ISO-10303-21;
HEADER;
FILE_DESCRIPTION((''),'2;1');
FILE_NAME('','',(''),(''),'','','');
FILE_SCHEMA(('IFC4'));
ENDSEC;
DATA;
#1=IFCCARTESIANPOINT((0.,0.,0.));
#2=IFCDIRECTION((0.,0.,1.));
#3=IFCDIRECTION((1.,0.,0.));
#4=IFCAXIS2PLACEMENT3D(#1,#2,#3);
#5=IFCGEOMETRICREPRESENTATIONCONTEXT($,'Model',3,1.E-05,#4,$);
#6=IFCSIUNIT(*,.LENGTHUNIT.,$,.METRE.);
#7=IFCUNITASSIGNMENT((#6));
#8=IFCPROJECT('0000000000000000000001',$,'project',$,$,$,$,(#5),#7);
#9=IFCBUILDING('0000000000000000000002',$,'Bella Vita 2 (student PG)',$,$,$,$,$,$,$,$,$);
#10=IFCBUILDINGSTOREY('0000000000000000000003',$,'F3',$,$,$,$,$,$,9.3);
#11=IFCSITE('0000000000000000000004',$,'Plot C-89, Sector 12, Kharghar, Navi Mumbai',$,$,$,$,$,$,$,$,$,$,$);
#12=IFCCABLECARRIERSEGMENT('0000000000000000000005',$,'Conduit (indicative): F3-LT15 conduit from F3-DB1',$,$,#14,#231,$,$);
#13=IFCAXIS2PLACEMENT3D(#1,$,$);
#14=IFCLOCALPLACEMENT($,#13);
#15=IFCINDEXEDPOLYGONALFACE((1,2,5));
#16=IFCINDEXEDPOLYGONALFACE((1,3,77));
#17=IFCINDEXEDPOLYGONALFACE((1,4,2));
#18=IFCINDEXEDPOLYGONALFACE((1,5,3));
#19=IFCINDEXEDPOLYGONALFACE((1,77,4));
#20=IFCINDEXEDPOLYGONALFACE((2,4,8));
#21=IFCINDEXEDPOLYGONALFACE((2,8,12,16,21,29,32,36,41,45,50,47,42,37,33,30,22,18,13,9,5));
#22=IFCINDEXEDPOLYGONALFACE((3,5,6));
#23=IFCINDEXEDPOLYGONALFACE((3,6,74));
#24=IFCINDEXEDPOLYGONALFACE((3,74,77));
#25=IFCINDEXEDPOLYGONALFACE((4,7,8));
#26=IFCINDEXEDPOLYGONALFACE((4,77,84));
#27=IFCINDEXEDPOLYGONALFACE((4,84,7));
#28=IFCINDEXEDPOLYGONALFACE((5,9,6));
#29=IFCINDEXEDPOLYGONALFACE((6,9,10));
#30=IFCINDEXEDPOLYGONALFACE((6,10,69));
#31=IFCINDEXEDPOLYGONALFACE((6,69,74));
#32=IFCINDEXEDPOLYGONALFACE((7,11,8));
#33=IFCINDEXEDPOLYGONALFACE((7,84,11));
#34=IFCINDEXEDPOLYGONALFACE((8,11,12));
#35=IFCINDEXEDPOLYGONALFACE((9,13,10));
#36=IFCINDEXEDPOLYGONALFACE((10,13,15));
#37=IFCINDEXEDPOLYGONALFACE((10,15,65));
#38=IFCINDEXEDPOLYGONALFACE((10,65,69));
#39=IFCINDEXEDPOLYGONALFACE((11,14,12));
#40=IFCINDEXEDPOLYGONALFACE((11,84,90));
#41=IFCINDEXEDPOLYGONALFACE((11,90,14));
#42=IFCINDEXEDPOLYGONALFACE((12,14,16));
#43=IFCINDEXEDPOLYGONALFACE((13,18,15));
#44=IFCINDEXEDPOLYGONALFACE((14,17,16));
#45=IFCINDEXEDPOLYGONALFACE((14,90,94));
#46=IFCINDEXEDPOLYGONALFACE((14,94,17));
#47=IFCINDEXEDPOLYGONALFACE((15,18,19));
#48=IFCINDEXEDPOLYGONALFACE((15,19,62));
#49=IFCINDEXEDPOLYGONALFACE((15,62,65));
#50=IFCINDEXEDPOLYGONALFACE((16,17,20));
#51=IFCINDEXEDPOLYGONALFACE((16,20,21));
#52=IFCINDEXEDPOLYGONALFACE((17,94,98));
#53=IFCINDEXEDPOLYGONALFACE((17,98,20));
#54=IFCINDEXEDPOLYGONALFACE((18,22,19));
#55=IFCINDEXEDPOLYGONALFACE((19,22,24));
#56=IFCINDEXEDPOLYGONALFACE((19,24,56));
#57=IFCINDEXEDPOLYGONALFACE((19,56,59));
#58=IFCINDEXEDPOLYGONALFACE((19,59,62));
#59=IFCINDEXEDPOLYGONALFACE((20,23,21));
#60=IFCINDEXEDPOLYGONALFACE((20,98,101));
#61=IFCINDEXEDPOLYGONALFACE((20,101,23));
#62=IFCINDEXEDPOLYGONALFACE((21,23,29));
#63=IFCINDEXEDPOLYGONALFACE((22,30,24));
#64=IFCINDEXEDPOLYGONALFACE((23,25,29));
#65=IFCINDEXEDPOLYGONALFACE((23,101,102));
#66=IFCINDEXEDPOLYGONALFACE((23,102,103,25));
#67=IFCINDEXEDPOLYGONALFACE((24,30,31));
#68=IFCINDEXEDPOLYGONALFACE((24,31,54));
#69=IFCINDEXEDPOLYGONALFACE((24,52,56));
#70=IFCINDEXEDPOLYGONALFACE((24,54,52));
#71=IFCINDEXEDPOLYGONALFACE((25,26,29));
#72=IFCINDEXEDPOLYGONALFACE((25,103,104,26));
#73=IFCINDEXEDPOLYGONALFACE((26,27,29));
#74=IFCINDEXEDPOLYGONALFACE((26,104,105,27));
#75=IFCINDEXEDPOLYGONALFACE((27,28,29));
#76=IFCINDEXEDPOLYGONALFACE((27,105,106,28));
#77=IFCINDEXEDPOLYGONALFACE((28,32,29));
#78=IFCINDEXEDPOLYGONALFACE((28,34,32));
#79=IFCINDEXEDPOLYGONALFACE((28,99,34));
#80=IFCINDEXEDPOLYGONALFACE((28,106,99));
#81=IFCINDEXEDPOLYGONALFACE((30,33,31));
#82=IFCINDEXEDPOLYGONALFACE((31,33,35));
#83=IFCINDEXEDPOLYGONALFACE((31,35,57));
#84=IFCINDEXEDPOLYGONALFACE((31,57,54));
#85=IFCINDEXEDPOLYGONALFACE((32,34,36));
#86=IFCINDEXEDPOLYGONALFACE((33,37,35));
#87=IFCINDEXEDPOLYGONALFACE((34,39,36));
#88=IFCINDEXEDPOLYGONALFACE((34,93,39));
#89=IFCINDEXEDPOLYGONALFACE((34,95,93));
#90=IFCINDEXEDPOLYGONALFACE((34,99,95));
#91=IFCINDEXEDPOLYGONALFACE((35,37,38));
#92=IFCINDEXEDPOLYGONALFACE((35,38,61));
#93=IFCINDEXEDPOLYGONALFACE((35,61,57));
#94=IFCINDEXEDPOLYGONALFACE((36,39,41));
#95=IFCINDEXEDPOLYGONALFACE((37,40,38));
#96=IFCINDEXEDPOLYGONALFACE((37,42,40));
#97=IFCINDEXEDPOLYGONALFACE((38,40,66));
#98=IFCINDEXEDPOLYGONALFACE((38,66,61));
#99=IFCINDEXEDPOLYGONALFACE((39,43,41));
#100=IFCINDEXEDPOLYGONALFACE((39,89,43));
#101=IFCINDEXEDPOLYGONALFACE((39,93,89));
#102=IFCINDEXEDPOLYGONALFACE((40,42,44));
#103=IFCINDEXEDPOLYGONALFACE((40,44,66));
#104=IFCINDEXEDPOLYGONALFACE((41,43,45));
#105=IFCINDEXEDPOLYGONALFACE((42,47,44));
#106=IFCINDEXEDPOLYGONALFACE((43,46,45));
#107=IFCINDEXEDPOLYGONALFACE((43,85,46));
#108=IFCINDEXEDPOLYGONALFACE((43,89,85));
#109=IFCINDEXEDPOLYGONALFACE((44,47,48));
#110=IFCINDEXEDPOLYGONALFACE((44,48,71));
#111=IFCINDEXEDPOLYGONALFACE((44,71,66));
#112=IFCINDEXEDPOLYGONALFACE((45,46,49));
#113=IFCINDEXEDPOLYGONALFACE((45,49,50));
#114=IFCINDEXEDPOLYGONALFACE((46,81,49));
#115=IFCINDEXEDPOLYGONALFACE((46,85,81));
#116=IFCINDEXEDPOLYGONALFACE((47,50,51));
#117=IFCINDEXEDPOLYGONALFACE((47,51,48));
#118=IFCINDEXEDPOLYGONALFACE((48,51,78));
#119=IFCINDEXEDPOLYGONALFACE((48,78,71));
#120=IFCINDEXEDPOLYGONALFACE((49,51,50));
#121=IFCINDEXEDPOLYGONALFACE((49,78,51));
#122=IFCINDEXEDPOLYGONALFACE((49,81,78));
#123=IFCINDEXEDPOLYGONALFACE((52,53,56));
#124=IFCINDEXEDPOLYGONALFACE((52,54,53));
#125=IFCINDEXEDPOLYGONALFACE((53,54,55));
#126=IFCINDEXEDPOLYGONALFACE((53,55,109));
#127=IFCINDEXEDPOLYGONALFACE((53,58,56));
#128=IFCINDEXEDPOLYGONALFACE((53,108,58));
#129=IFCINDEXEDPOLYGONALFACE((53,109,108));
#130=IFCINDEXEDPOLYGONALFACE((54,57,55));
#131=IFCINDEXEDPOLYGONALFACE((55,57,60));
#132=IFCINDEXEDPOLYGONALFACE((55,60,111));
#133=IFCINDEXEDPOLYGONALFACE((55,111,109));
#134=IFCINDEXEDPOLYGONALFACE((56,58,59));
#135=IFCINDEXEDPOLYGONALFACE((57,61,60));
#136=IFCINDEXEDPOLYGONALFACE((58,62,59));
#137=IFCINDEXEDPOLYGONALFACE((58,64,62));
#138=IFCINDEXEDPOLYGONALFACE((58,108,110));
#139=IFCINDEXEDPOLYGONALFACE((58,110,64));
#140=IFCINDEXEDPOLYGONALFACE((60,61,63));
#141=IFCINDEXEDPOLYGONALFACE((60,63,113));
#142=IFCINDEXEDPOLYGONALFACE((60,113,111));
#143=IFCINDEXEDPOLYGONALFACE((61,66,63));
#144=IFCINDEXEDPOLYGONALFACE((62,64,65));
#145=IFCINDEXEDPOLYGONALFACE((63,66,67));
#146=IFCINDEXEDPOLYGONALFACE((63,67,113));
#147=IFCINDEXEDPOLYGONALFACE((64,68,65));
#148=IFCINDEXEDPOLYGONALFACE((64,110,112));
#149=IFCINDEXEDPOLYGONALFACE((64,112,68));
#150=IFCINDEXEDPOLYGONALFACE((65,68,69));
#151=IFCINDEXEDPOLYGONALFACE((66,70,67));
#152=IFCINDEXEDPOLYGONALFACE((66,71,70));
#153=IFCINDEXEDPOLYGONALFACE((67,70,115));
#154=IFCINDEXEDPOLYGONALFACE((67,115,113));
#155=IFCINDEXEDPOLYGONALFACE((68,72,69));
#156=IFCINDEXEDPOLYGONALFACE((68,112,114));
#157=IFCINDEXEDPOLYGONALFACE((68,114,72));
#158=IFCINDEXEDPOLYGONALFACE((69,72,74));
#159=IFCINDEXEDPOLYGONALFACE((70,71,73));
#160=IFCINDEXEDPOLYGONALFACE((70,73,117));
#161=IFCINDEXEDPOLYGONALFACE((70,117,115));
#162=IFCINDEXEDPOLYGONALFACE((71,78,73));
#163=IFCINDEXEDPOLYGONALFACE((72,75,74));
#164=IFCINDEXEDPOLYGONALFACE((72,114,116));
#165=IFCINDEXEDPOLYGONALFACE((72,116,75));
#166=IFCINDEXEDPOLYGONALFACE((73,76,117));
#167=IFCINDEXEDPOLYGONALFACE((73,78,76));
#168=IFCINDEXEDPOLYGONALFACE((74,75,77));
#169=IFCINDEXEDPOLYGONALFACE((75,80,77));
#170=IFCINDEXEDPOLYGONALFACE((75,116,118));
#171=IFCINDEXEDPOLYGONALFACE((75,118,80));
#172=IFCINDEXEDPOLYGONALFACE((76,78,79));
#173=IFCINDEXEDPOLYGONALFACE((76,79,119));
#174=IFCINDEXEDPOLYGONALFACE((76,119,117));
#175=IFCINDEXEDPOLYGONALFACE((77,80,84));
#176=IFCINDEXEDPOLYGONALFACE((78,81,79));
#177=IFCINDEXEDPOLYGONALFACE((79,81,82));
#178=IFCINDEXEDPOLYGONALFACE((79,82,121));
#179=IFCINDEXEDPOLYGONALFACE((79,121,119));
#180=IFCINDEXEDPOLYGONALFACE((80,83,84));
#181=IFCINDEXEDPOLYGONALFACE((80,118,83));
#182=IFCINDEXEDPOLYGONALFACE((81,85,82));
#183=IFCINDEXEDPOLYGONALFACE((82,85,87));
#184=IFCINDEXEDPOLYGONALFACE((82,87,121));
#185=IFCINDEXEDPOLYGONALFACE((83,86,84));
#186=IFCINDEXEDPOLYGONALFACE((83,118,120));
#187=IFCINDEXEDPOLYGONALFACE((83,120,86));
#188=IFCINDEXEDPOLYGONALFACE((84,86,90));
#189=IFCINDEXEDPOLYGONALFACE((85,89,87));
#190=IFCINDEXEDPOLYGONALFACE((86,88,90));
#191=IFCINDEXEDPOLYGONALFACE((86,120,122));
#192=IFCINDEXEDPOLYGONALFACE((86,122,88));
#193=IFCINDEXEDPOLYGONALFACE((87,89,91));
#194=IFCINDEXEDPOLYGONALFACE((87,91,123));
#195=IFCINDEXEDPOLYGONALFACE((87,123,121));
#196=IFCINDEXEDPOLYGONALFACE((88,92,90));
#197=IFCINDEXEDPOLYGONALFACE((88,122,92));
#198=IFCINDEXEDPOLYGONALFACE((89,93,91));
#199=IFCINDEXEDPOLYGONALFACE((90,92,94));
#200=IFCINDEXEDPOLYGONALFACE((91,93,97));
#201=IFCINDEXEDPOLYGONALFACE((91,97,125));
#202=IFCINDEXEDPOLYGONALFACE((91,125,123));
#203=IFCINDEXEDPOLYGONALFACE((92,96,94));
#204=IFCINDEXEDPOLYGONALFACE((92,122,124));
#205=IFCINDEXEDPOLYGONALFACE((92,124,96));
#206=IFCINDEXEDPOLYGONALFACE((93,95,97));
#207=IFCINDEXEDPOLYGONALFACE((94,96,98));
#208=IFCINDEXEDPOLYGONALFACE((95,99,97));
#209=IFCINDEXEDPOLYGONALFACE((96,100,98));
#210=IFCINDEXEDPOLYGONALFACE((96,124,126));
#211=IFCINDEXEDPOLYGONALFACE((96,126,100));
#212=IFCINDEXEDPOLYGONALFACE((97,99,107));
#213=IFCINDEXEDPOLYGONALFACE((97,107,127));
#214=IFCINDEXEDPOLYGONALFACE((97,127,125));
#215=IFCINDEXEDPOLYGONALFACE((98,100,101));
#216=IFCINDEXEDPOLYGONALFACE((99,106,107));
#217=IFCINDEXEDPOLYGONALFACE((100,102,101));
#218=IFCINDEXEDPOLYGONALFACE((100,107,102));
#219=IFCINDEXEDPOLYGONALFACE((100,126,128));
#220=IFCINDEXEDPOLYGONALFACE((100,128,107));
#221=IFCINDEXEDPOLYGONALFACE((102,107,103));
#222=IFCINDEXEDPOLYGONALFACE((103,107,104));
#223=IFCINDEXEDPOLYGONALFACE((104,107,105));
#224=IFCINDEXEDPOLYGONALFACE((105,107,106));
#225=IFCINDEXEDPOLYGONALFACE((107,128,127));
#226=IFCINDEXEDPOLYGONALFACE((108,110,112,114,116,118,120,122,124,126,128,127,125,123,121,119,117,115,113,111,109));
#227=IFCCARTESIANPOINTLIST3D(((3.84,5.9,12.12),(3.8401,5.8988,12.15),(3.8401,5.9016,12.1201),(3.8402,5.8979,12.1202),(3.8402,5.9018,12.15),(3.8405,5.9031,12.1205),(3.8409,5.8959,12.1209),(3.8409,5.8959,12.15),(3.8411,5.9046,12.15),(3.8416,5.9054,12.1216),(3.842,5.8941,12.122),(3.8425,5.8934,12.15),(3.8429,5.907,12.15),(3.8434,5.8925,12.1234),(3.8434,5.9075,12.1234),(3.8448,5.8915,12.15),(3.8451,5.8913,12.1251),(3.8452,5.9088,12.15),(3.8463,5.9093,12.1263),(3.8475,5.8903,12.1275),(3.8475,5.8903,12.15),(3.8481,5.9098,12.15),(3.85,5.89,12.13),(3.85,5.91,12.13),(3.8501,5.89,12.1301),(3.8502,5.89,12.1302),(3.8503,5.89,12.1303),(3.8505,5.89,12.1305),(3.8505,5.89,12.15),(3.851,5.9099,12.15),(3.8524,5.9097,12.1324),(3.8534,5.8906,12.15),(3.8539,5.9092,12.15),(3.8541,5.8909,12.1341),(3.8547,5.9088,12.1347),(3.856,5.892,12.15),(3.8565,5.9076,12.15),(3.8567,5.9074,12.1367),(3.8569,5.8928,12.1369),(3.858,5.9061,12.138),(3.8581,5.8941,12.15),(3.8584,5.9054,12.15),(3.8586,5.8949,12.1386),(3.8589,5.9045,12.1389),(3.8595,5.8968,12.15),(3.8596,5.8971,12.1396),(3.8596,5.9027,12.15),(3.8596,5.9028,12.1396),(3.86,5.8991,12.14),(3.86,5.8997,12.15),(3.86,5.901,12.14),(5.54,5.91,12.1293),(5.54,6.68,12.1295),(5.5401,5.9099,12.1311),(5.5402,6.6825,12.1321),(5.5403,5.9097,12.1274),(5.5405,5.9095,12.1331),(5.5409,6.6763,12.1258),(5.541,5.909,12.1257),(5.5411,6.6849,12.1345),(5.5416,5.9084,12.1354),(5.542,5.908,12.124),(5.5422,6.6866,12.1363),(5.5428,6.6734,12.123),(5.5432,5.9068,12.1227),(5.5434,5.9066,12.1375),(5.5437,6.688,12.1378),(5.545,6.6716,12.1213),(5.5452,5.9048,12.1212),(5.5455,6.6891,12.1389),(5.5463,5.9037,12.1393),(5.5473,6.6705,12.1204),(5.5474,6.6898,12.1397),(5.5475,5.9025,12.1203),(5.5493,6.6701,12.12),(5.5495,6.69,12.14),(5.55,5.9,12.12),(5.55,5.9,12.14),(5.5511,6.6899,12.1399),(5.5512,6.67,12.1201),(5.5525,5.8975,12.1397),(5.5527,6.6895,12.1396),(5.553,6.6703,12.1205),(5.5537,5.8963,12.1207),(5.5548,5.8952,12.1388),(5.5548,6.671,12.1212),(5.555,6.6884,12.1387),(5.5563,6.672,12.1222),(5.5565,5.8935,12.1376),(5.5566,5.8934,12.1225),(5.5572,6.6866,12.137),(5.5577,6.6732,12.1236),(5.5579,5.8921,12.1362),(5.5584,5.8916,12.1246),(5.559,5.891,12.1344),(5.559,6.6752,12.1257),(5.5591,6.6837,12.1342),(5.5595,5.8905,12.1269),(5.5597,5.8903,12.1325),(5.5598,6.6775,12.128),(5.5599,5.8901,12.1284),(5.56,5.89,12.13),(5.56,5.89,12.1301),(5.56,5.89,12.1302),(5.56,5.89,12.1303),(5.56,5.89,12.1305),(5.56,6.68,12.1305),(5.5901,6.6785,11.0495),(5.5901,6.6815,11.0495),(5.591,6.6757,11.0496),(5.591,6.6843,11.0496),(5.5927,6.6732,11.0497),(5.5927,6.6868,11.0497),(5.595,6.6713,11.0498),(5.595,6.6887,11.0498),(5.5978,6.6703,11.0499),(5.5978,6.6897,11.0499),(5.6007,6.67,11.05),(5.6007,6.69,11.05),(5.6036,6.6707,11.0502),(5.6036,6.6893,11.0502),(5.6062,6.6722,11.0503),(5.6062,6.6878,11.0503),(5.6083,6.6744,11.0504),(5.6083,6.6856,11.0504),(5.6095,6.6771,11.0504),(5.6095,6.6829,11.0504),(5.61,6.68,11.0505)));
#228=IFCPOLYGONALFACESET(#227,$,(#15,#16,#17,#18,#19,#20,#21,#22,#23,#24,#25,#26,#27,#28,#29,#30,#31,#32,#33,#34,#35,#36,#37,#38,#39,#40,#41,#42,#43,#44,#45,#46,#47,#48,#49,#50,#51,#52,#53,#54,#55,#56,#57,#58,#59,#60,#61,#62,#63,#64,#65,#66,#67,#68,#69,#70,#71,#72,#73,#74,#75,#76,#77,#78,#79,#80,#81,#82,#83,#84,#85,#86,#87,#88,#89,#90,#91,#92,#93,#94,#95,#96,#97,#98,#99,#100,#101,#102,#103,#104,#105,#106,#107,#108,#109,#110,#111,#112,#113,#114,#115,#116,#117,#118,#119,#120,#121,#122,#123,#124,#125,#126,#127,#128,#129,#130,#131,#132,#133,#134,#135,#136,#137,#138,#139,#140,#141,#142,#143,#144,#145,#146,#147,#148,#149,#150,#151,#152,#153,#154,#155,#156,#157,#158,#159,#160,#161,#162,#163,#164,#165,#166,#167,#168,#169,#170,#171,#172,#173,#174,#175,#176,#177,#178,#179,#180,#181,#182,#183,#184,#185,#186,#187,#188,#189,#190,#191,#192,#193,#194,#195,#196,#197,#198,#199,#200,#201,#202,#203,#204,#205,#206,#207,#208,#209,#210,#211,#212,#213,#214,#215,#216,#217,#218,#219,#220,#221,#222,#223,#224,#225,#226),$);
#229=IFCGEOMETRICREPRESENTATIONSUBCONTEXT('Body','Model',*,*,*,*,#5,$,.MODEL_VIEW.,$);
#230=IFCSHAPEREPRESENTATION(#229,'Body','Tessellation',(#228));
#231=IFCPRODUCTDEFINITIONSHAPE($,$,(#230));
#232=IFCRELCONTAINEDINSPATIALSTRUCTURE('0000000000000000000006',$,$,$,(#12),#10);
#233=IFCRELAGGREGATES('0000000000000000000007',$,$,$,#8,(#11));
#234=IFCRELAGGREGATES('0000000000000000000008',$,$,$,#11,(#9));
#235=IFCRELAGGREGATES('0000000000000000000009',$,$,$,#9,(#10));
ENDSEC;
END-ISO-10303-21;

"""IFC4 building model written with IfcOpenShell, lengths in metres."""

from ifc_helpers import new_model, entity, si_unit, origin, origin_with_axes, place, context, subcontext, project, spatial, element, save


model = new_model("IFC4")

# Units and contexts
model_context = context("Model", 3, precision=1e-05, world=origin_with_axes())
body_context = subcontext(model_context, "Body", "Model", "MODEL_VIEW")
ifc_project = project(units=[si_unit("LENGTHUNIT", "METRE")], contexts=[model_context])

# Site, building, storey
site = spatial("IfcSite", under=ifc_project, Name="Plot C-89, Sector 12, Kharghar, Navi Mumbai")
building = spatial("IfcBuilding", under=site, Name="Bella Vita 2 (student PG)")
storey = spatial("IfcBuildingStorey", under=building, Name="F3", Elevation=9.3)

# Cable carrier segment
cable_carrier_segment_1_placement = place(None, origin())
element("IfcCableCarrierSegment", 1, at=cable_carrier_segment_1_placement, inside=storey, Name="Conduit (indicative): F3-LT15 conduit from F3-DB1", context=body_context, shape_type="AdvancedSweptSolid", body=[
    entity("IfcSweptDiskSolid", entity("IfcPolyline", [entity("IfcCartesianPoint", [5.6, 6.68, 11.05]), entity("IfcCartesianPoint", [5.55, 6.68, 12.13]), entity("IfcCartesianPoint", [5.55, 5.9, 12.13]), entity("IfcCartesianPoint", [3.85, 5.9, 12.13]), entity("IfcCartesianPoint", [3.85, 5.9, 12.15])]), 0.01),
])

save(model, "model.ifc")
